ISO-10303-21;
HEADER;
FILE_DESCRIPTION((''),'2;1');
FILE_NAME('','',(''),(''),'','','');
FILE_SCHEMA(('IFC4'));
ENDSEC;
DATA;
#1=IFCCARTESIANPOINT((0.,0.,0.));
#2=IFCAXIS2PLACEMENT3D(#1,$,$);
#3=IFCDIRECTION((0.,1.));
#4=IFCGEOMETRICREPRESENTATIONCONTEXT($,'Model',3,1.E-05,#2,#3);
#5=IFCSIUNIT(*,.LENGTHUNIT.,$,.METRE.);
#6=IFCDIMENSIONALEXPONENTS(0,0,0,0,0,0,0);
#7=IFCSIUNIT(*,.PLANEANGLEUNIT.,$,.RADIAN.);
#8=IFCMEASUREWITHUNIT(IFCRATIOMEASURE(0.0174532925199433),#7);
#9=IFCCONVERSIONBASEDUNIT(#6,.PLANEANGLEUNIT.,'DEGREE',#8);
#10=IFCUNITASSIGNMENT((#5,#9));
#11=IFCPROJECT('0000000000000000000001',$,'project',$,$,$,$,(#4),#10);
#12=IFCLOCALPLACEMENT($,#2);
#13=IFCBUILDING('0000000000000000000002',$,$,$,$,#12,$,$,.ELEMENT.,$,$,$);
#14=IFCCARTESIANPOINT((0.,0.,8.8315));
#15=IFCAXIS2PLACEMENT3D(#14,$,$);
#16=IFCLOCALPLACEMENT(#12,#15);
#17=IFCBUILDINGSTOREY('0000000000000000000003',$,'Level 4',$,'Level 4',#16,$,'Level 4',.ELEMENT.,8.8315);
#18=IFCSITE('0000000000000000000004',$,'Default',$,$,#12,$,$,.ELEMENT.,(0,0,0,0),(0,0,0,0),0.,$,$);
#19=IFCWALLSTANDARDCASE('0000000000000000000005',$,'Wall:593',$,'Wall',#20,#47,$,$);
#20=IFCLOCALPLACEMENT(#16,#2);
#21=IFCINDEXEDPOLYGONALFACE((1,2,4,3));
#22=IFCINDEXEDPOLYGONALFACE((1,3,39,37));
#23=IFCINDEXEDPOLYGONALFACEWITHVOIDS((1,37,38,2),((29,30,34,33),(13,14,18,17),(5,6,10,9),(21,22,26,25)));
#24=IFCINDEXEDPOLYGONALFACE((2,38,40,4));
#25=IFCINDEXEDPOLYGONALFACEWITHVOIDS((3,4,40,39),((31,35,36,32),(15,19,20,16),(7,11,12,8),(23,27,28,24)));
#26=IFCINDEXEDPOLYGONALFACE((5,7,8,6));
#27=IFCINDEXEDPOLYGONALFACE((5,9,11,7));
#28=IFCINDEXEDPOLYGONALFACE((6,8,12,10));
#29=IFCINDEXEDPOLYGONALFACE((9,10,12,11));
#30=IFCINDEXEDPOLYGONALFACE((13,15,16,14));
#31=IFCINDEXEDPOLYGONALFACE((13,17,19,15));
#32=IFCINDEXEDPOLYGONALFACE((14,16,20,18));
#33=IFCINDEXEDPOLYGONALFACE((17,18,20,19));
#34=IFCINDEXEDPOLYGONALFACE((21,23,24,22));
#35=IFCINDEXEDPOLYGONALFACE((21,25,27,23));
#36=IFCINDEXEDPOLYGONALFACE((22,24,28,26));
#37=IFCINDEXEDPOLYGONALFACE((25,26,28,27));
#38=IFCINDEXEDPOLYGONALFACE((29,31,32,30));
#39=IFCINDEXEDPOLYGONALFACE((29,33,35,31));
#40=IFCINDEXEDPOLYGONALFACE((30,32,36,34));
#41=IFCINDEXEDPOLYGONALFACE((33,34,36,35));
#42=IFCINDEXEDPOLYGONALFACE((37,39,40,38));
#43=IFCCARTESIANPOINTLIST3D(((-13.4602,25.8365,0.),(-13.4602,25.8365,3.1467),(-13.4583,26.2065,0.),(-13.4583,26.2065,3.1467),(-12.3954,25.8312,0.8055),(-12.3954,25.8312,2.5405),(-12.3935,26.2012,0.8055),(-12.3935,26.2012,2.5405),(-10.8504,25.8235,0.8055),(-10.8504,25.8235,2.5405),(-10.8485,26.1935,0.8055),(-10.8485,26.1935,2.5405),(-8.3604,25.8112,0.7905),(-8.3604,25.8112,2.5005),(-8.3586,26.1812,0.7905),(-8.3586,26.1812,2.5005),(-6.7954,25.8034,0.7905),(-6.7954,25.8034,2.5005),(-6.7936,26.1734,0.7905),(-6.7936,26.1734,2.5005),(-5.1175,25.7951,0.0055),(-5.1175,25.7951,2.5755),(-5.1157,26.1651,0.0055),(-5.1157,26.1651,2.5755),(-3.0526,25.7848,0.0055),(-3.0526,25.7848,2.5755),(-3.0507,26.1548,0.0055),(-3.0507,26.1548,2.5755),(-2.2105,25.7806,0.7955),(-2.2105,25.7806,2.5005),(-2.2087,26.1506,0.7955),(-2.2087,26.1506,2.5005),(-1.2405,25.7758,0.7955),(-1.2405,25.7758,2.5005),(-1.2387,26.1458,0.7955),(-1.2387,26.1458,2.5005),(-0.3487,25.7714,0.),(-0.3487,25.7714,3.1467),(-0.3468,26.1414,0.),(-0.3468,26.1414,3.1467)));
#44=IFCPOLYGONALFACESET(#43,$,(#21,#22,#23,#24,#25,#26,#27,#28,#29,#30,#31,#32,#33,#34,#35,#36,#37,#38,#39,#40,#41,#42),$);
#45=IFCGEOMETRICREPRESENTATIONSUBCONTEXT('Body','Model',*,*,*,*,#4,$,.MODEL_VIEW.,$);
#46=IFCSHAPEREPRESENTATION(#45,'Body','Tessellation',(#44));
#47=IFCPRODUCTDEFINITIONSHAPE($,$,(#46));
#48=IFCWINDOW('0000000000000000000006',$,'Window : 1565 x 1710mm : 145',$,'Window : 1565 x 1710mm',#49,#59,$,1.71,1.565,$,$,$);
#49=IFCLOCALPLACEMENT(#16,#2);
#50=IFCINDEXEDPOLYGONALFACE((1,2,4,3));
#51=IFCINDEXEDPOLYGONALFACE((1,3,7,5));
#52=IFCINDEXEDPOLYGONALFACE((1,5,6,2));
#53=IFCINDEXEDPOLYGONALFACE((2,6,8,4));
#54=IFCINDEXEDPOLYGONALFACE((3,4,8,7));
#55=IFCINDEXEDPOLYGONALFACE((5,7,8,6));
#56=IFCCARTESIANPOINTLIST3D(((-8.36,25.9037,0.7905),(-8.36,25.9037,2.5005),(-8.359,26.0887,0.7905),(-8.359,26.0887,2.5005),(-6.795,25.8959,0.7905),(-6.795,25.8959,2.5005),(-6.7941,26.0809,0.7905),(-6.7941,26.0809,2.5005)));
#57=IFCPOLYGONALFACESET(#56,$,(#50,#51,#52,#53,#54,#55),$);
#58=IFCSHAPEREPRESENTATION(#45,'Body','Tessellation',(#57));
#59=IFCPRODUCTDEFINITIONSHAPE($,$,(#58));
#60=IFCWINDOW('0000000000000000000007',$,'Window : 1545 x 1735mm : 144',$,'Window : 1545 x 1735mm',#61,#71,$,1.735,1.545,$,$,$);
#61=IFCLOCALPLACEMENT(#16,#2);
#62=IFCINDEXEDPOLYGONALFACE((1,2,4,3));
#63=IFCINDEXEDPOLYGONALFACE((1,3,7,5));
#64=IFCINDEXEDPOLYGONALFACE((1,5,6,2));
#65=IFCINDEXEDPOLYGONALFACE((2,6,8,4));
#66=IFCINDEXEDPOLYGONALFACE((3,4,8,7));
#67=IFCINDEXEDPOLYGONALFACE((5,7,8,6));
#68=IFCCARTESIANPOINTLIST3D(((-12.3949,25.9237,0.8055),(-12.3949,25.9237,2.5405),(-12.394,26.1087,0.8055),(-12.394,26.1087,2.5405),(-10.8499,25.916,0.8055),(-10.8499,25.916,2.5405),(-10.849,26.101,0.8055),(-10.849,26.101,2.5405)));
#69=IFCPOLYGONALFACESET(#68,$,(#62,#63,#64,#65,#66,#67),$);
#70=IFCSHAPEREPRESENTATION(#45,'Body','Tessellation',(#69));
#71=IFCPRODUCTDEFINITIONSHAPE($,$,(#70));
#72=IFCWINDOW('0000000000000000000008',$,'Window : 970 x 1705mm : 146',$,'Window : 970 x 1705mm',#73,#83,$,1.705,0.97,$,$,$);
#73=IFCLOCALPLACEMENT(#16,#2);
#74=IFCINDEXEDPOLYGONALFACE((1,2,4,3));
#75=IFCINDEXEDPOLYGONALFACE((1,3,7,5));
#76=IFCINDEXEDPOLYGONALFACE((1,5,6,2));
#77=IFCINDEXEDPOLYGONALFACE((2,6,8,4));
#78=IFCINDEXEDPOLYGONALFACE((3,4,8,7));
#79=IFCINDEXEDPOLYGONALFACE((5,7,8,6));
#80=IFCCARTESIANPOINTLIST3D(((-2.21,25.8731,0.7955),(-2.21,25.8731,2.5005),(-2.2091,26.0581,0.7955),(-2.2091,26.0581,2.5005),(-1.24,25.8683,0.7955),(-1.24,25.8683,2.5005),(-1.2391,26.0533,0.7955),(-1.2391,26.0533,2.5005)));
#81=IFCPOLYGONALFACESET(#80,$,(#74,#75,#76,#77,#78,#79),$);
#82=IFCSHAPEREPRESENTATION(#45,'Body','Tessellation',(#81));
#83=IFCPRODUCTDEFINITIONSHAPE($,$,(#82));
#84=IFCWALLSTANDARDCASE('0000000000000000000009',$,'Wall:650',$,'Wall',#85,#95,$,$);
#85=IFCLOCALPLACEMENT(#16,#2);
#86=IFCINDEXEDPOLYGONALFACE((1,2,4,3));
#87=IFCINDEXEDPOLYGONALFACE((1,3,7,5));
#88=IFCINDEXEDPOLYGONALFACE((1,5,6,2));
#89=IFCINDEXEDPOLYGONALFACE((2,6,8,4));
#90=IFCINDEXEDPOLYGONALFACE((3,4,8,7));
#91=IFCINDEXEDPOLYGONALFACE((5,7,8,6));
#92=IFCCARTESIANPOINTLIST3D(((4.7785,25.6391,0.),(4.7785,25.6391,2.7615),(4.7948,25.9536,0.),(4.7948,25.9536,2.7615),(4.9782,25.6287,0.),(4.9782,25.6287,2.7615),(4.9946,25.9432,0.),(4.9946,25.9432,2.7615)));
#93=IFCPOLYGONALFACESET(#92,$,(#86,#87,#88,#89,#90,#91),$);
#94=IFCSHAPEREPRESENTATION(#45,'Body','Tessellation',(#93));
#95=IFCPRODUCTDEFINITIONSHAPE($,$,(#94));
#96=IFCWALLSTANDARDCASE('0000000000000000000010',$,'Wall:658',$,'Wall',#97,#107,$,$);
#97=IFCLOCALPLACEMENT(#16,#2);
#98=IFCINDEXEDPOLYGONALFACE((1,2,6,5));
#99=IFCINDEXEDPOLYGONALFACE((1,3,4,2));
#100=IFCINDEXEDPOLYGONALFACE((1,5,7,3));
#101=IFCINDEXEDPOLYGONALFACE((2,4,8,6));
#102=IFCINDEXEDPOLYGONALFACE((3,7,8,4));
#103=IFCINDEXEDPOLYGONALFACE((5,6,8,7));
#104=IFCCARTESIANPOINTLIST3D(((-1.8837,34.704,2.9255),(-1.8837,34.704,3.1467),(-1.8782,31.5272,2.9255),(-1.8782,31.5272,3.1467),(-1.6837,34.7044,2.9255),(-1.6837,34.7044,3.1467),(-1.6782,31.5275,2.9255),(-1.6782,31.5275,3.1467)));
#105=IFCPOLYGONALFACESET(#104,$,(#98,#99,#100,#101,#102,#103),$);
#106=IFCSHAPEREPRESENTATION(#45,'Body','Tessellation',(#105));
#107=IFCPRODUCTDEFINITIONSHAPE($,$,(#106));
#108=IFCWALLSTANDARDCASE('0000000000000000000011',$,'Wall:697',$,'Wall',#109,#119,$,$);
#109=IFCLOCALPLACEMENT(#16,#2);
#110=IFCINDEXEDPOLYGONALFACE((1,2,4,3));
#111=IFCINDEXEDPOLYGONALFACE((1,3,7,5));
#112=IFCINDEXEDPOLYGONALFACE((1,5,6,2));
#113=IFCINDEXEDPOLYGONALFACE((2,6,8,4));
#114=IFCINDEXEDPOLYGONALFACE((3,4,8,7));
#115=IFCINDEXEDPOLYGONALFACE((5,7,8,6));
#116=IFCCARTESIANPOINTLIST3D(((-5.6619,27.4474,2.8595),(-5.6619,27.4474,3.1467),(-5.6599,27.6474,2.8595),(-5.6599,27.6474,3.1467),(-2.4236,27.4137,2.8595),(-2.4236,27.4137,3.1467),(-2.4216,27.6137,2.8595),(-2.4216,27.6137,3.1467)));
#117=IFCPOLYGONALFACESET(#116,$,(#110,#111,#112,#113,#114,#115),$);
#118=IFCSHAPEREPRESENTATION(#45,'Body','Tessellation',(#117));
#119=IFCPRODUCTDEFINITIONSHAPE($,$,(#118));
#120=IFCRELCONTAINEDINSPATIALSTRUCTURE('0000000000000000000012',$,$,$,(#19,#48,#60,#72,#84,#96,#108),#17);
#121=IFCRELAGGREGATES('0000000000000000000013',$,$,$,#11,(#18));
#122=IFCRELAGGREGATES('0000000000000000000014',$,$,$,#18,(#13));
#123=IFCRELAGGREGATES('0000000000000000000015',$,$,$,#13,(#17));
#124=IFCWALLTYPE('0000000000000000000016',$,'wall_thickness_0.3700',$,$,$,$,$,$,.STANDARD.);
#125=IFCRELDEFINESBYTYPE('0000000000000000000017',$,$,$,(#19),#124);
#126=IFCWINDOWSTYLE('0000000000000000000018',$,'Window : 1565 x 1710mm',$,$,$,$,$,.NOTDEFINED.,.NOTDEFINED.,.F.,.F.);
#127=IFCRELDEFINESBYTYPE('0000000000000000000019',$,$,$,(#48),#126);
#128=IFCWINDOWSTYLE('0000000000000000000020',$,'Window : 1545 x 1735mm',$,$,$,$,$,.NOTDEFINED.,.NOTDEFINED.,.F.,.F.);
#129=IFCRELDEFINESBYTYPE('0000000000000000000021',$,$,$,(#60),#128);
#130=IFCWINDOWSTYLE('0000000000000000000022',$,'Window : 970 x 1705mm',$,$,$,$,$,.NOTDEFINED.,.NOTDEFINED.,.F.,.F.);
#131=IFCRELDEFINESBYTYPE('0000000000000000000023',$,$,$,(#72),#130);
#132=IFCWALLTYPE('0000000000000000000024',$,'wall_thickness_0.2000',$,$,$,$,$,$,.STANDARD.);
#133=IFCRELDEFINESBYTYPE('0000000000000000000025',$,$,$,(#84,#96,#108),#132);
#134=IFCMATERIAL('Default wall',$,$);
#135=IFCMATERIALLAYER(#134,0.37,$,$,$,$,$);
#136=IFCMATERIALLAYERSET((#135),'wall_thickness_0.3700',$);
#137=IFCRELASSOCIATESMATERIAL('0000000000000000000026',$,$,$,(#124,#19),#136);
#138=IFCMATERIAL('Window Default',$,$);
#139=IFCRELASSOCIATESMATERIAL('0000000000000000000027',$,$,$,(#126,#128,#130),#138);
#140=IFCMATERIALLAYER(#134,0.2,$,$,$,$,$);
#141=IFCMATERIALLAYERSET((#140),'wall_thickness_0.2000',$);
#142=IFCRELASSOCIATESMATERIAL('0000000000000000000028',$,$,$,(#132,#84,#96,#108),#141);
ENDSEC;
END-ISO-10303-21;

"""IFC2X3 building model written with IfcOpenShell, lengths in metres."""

from ifc_helpers import new_model, entity, si_unit, converted_unit, direction, frame, frame_2d, origin, origin_2d_with_axis, place, context, subcontext, project, spatial, polyline, rectangle, outline, extrude, source, transform, mapped, material, layer, layer_set, layer_usage, type_object, type_shapes, element, fill, save


model = new_model("IFC2X3")

# Units and contexts
model_context = context("Model", 3, precision=1e-05, world=origin(), true_north=direction((0.0, 1.0)))
body_context = subcontext(model_context, "Body", "Model", "MODEL_VIEW")
ifc_project = project(units=[si_unit("LENGTHUNIT", "METRE"), converted_unit("PLANEANGLEUNIT", "DEGREE", entity("IfcRatioMeasure", 0.0174532925199433), si_unit("PLANEANGLEUNIT", "RADIAN"), dimensions=[0, 0, 0, 0, 0, 0, 0])], contexts=[model_context])

# Site, building, storey
placement_1 = place(None, origin())
site = spatial("IfcSite", under=ifc_project, at=placement_1, Name="Default", CompositionType="ELEMENT", RefLatitude=(0, 0, 0, 0), RefLongitude=(0, 0, 0, 0), RefElevation=0.0)
building = spatial("IfcBuilding", under=site, at=placement_1, CompositionType="ELEMENT")
storey_placement = place(placement_1, frame((0.0, 0.0, 8.8315)))
storey = spatial("IfcBuildingStorey", under=building, at=storey_placement, Name="Level 4", ObjectType="Level 4", LongName="Level 4", CompositionType="ELEMENT", Elevation=8.8315)

# Shared definitions
ifc_material_1 = material(Name="Default wall")

# Shared definitions
ifc_material_2 = material(Name="Window Default")

# Wall, openings, windows
ifc_layer_1 = layer(ifc_material_1, 0.37)
ifc_layer_set_1 = layer_set([ifc_layer_1], Name="wall_thickness_0.3700")
ifc_layer_usage_1 = layer_usage(ifc_layer_set_1, "AXIS2", "POSITIVE", -0.185)
wall_type_1 = type_object("IfcWallType", Name="wall_thickness_0.3700", PredefinedType="STANDARD", material=ifc_layer_set_1)
wall_1_placement = place(storey_placement, frame((-13.4593, 26.0215, 0.0), z_axis=(0.0, 0.0, 1.0), x_axis=(0.999988, -0.004969, 0.0)))
wall_1 = element("IfcWallStandardCase", 1, at=wall_1_placement, inside=storey, type_object=wall_type_1, material=ifc_layer_usage_1, Name="Wall:593", ObjectType="Wall", context=body_context, shape_type="SweptSolid", body=[
    extrude(outline(polyline([(13.1117, -0.185), (13.1117, 0.185), (0.0, 0.185), (0.0, -0.185), (13.1117, -0.185)])), origin(), (0.0, 0.0, 1.0), 3.1467),
])
opening_1_placement = place(wall_1_placement, frame((8.3427, -0.185, 0.0055)))
element("IfcOpeningElement", 2, at=opening_1_placement, cuts=wall_1, ObjectType="Opening", context=body_context, shape_type="SweptSolid", body=[
    extrude(rectangle(XDim=2.065, YDim=2.57, at=frame_2d((1.285, 1.0325), x_axis=(0.0, 1.0))), frame((0.0, 0.0, 0.0), z_axis=(0.0, 1.0, 0.0), x_axis=(0.0, 0.0, 1.0)), (0.0, 0.0, 1.0), 0.37),
])
opening_2_placement = place(wall_1_placement, frame((1.0648, -0.185, 0.8055)))
opening_2 = element("IfcOpeningElement", 3, at=opening_2_placement, cuts=wall_1, ObjectType="Opening", context=body_context, shape_type="SweptSolid", body=[
    extrude(rectangle(XDim=1.545, YDim=1.735, at=frame_2d((0.8675, 0.7725), x_axis=(0.0, 1.0))), frame((0.0, 0.0, 0.0), z_axis=(0.0, 1.0, 0.0), x_axis=(0.0, 0.0, 1.0)), (0.0, 0.0, 1.0), 0.37),
])
opening_3_placement = place(wall_1_placement, frame((5.0998, -0.185, 0.7905)))
opening_3 = element("IfcOpeningElement", 4, at=opening_3_placement, cuts=wall_1, ObjectType="Opening", context=body_context, shape_type="SweptSolid", body=[
    extrude(rectangle(XDim=1.565, YDim=1.71, at=frame_2d((0.855, 0.7825), x_axis=(0.0, 1.0))), frame((0.0, 0.0, 0.0), z_axis=(0.0, 1.0, 0.0), x_axis=(0.0, 0.0, 1.0)), (0.0, 0.0, 1.0), 0.37),
])
opening_4_placement = place(wall_1_placement, frame((11.2498, -0.185, 0.7955)))
opening_4 = element("IfcOpeningElement", 5, at=opening_4_placement, cuts=wall_1, ObjectType="Opening", context=body_context, shape_type="SweptSolid", body=[
    extrude(rectangle(XDim=0.97, YDim=1.705, at=frame_2d((0.8525, 0.485), x_axis=(0.0, 1.0))), frame((0.0, 0.0, 0.0), z_axis=(0.0, 1.0, 0.0), x_axis=(0.0, 0.0, 1.0)), (0.0, 0.0, 1.0), 0.37),
])
window_style_1 = type_object("IfcWindowStyle", Name="Window : 1565 x 1710mm", ConstructionType="NOTDEFINED", OperationType="NOTDEFINED", ParameterTakesPrecedence=False, Sizeable=False, material=ifc_material_2)
shared_shape_1 = source(origin(), body_context, "Body", "SweptSolid", [
    extrude(rectangle(XDim=0.185, YDim=1.565, at=origin_2d_with_axis()), frame((0.7825, 0.185, 0.0), z_axis=(0.0, 0.0, 1.0), x_axis=(0.0, 1.0, 0.0)), (0.0, 0.0, 1.0), 1.71),
])
type_shapes(window_style_1, [shared_shape_1])
window_1_placement = place(opening_3_placement, origin())
window_1 = element("IfcWindow", 6, at=window_1_placement, inside=storey, type_object=window_style_1, Name="Window : 1565 x 1710mm : 145", ObjectType="Window : 1565 x 1710mm", OverallHeight=1.71, OverallWidth=1.565, context=body_context, shape_type="MappedRepresentation", body=[
    mapped(shared_shape_1, transform((0.0, 0.0, 0.0), scale=1.0)),
])
fill(opening_3, window_1)
window_style_2 = type_object("IfcWindowStyle", Name="Window : 1545 x 1735mm", ConstructionType="NOTDEFINED", OperationType="NOTDEFINED", ParameterTakesPrecedence=False, Sizeable=False, material=ifc_material_2)
shared_shape_2 = source(origin(), body_context, "Body", "SweptSolid", [
    extrude(rectangle(XDim=0.185, YDim=1.545, at=origin_2d_with_axis()), frame((0.7725, 0.185, 0.0), z_axis=(0.0, 0.0, 1.0), x_axis=(0.0, 1.0, 0.0)), (0.0, 0.0, 1.0), 1.735),
])
type_shapes(window_style_2, [shared_shape_2])
window_2_placement = place(opening_2_placement, origin())
window_2 = element("IfcWindow", 7, at=window_2_placement, inside=storey, type_object=window_style_2, Name="Window : 1545 x 1735mm : 144", ObjectType="Window : 1545 x 1735mm", OverallHeight=1.735, OverallWidth=1.545, context=body_context, shape_type="MappedRepresentation", body=[
    mapped(shared_shape_2, transform((0.0, 0.0, 0.0), scale=1.0)),
])
fill(opening_2, window_2)
window_style_3 = type_object("IfcWindowStyle", Name="Window : 970 x 1705mm", ConstructionType="NOTDEFINED", OperationType="NOTDEFINED", ParameterTakesPrecedence=False, Sizeable=False, material=ifc_material_2)
shared_shape_3 = source(origin(), body_context, "Body", "SweptSolid", [
    extrude(rectangle(XDim=0.185, YDim=0.97, at=origin_2d_with_axis()), frame((0.485, 0.185, 0.0), z_axis=(0.0, 0.0, 1.0), x_axis=(0.0, 1.0, 0.0)), (0.0, 0.0, 1.0), 1.705),
])
type_shapes(window_style_3, [shared_shape_3])
window_3_placement = place(opening_4_placement, origin())
window_3 = element("IfcWindow", 8, at=window_3_placement, inside=storey, type_object=window_style_3, Name="Window : 970 x 1705mm : 146", ObjectType="Window : 970 x 1705mm", OverallHeight=1.705, OverallWidth=0.97, context=body_context, shape_type="MappedRepresentation", body=[
    mapped(shared_shape_3, transform((0.0, 0.0, 0.0), scale=1.0)),
])
fill(opening_4, window_3)

# Walls
ifc_layer_2 = layer(ifc_material_1, 0.2)
ifc_layer_set_2 = layer_set([ifc_layer_2], Name="wall_thickness_0.2000")
ifc_layer_usage_2 = layer_usage(ifc_layer_set_2, "AXIS2", "POSITIVE", -0.1)
wall_type_2 = type_object("IfcWallType", Name="wall_thickness_0.2000", PredefinedType="STANDARD", material=ifc_layer_set_2)
wall_2_placement = place(storey_placement, frame((4.8783, 25.6339, 0.0), z_axis=(0.0, 0.0, 1.0), x_axis=(0.052001, 0.998647, 0.0)))
element("IfcWallStandardCase", 9, at=wall_2_placement, inside=storey, type_object=wall_type_2, material=ifc_layer_usage_2, Name="Wall:650", ObjectType="Wall", context=body_context, shape_type="SweptSolid", body=[
    extrude(outline(polyline([(0.315, -0.1), (0.315, 0.1), (0.0, 0.1), (0.0, -0.1), (0.315, -0.1)])), origin(), (0.0, 0.0, 1.0), 2.7615),
])
placement_2 = place(placement_1, frame((0.0, 0.0, 11.757)))
wall_3_placement = place(placement_2, frame((-1.7837, 34.7042, 0.0), z_axis=(0.0, 0.0, 1.0), x_axis=(0.001709, -0.999999, 0.0)))
element("IfcWallStandardCase", 10, at=wall_3_placement, inside=storey, type_object=wall_type_2, material=ifc_layer_usage_2, Name="Wall:658", ObjectType="Wall", context=body_context, shape_type="SweptSolid", body=[
    extrude(outline(polyline([(3.1769, -0.1), (3.1769, 0.1), (0.0, 0.1), (0.0, -0.1), (3.1769, -0.1)])), origin(), (0.0, 0.0, 1.0), 0.2212),
])
placement_3 = place(placement_1, frame((0.0, 0.0, 11.691)))
wall_4_placement = place(placement_3, frame((-5.6609, 27.5474, 0.0), z_axis=(0.0, 0.0, 1.0), x_axis=(0.999946, -0.010392, 0.0)))
element("IfcWallStandardCase", 11, at=wall_4_placement, inside=storey, type_object=wall_type_2, material=ifc_layer_usage_2, Name="Wall:697", ObjectType="Wall", context=body_context, shape_type="SweptSolid", body=[
    extrude(outline(polyline([(3.2385, -0.1), (3.2385, 0.1), (0.0, 0.1), (0.0, -0.1), (3.2385, -0.1)])), origin(), (0.0, 0.0, 1.0), 0.2872),
])

save(model, "model.ifc")
